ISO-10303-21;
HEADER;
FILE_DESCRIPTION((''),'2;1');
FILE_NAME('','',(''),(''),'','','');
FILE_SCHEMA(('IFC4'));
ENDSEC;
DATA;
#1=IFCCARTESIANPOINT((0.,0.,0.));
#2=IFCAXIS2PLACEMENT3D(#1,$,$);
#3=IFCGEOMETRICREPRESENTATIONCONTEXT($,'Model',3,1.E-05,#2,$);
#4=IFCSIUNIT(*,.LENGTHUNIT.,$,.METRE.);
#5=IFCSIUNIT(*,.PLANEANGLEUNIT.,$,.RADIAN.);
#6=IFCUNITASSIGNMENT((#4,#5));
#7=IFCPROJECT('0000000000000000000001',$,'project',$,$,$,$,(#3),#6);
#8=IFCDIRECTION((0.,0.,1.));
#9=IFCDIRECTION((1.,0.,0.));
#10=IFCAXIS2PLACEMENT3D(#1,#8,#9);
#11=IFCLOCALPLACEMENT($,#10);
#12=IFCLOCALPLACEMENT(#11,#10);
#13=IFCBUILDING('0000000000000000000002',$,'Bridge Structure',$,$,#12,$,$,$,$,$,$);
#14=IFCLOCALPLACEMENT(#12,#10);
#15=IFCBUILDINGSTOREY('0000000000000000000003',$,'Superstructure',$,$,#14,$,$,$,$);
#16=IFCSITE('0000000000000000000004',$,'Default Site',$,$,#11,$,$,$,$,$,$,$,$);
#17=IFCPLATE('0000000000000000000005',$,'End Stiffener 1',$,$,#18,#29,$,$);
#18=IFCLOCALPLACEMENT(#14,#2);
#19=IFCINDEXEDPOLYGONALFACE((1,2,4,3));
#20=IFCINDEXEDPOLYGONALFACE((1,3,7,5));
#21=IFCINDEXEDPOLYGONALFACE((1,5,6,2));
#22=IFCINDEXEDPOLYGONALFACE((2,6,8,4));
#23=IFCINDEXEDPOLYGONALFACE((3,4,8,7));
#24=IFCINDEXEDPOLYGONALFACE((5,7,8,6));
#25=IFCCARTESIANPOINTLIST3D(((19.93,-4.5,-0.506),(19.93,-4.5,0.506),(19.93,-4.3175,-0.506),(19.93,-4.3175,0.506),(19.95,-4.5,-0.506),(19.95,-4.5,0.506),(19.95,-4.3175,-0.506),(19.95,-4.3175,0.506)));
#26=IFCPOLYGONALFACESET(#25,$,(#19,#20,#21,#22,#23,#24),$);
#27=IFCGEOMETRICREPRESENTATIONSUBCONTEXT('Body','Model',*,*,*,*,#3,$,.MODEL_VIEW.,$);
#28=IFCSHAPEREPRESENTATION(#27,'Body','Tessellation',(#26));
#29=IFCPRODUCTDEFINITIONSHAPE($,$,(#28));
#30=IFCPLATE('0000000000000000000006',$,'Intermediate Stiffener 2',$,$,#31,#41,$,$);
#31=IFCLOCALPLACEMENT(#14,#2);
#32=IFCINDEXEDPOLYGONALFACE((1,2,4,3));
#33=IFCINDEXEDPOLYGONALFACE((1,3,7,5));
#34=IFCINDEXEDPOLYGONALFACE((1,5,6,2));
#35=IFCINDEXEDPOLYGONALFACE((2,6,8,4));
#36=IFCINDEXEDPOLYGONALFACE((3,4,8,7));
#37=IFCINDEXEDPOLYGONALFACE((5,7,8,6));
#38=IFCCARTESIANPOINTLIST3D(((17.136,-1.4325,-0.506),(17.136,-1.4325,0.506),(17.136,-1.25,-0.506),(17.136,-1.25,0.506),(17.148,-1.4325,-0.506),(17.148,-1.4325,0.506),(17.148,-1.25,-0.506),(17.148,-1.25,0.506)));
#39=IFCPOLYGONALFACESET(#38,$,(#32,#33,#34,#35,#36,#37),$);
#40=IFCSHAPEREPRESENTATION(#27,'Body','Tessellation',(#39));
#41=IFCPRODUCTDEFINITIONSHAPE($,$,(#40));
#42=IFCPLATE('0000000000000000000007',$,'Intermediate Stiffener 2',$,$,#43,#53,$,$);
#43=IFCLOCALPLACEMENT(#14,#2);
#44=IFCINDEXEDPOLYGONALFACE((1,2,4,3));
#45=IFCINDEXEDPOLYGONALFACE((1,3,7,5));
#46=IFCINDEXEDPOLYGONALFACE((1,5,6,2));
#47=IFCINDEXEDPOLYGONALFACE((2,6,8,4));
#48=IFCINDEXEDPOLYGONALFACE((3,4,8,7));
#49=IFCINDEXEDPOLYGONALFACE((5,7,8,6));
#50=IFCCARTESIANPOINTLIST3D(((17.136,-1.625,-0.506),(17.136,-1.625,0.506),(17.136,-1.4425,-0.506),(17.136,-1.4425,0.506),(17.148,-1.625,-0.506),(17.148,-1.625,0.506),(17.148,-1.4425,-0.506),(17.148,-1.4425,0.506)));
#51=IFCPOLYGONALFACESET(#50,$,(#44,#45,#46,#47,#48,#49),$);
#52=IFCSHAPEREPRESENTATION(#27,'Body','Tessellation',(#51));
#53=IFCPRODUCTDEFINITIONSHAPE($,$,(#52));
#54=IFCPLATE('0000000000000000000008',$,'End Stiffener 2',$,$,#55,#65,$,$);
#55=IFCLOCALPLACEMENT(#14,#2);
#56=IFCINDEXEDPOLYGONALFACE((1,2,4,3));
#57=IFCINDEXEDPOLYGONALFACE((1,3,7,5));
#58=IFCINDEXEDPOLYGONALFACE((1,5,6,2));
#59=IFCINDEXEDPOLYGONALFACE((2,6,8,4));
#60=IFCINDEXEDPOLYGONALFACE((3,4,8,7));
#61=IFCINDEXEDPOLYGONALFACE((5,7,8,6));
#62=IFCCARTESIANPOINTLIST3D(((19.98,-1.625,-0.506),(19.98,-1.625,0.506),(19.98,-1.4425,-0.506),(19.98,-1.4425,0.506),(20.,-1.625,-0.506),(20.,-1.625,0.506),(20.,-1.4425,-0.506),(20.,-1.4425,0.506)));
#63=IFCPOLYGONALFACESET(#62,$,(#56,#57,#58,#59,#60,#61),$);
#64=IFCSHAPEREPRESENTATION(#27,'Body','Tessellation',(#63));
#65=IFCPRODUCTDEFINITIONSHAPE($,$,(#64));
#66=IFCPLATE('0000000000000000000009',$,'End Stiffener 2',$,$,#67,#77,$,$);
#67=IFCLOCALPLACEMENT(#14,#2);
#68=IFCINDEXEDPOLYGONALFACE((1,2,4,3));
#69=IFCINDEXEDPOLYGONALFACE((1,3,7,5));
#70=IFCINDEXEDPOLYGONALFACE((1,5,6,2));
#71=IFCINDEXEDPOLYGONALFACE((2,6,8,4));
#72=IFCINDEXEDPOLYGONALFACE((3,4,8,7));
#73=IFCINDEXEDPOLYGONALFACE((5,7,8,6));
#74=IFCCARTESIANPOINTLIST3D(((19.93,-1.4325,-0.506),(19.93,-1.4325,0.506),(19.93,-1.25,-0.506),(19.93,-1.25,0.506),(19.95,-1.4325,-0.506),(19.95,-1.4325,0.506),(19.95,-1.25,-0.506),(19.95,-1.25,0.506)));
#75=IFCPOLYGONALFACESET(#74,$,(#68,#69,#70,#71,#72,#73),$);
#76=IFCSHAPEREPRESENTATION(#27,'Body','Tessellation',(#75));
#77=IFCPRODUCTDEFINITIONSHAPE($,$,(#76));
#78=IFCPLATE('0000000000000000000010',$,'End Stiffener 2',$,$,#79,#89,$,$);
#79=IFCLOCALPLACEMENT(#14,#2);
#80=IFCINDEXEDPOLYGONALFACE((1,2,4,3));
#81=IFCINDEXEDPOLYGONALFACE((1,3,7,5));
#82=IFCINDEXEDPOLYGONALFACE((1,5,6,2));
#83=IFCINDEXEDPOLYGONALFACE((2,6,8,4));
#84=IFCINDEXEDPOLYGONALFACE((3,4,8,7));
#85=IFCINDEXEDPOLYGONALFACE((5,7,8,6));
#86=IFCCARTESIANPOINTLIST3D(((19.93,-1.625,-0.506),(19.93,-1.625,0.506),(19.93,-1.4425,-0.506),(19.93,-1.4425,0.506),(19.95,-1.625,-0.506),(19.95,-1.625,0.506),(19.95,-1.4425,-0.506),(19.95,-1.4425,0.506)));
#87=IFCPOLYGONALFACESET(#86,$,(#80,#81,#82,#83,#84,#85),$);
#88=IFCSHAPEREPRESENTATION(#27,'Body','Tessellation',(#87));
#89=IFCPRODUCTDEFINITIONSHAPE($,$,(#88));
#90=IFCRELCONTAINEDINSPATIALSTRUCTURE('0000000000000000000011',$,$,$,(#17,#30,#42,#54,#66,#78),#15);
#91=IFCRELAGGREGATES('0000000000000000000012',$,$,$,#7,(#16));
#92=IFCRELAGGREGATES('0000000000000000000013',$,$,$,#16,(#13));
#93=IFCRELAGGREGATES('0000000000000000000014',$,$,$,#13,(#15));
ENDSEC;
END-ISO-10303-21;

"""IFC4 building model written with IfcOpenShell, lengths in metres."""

from ifc_helpers import new_model, si_unit, frame, origin, origin_with_axes, origin_2d_with_axis, place, context, subcontext, project, spatial, rectangle, extrude, element, save


model = new_model("IFC4")

# Units and contexts
model_context = context("Model", 3, precision=1e-05, world=origin())
body_context = subcontext(model_context, "Body", "Model", "MODEL_VIEW")
ifc_project = project(units=[si_unit("LENGTHUNIT", "METRE"), si_unit("PLANEANGLEUNIT", "RADIAN")], contexts=[model_context])

# Site, building, storey
site_placement = place(None, origin_with_axes())
site = spatial("IfcSite", under=ifc_project, at=site_placement, Name="Default Site")
building_placement = place(site_placement, origin_with_axes())
building = spatial("IfcBuilding", under=site, at=building_placement, Name="Bridge Structure")
storey_placement = place(building_placement, origin_with_axes())
storey = spatial("IfcBuildingStorey", under=building, at=storey_placement, Name="Superstructure")

# Plates
for number, where, z_axis, x_axis, name in (
    (1, (19.94, -4.4088, -0.506), (0.0, 0.0, 1.0), (1.0, 0.0, 0.0), "End Stiffener 1"),
):
    element("IfcPlate", number, at=place(storey_placement, frame(where, z_axis=z_axis, x_axis=x_axis)), inside=storey, Name=name, context=body_context, shape_type="SweptSolid", body=[
        extrude(rectangle(XDim=0.02, YDim=0.1825, at=origin_2d_with_axis()), origin_with_axes(), (0.0, 0.0, 1.0), 1.012),
    ])
for number, where, z_axis, x_axis, name in (
    (2, (17.142, -1.3413, -0.506), (0.0, 0.0, 1.0), (1.0, 0.0, 0.0), "Intermediate Stiffener 2"),
    (3, (17.142, -1.5337, -0.506), (0.0, 0.0, 1.0), (1.0, 0.0, 0.0), "Intermediate Stiffener 2"),
):
    element("IfcPlate", number, at=place(storey_placement, frame(where, z_axis=z_axis, x_axis=x_axis)), inside=storey, Name=name, context=body_context, shape_type="SweptSolid", body=[
        extrude(rectangle(XDim=0.012, YDim=0.1825, at=origin_2d_with_axis()), origin_with_axes(), (0.0, 0.0, 1.0), 1.012),
    ])
for number, where, z_axis, x_axis, name in (
    (4, (19.99, -1.5337, -0.506), (0.0, 0.0, 1.0), (1.0, 0.0, 0.0), "End Stiffener 2"),
    (5, (19.94, -1.3413, -0.506), (0.0, 0.0, 1.0), (1.0, 0.0, 0.0), "End Stiffener 2"),
    (6, (19.94, -1.5337, -0.506), (0.0, 0.0, 1.0), (1.0, 0.0, 0.0), "End Stiffener 2"),
):
    element("IfcPlate", number, at=place(storey_placement, frame(where, z_axis=z_axis, x_axis=x_axis)), inside=storey, Name=name, context=body_context, shape_type="SweptSolid", body=[
        extrude(rectangle(XDim=0.02, YDim=0.1825, at=origin_2d_with_axis()), origin_with_axes(), (0.0, 0.0, 1.0), 1.012),
    ])

save(model, "model.ifc")
